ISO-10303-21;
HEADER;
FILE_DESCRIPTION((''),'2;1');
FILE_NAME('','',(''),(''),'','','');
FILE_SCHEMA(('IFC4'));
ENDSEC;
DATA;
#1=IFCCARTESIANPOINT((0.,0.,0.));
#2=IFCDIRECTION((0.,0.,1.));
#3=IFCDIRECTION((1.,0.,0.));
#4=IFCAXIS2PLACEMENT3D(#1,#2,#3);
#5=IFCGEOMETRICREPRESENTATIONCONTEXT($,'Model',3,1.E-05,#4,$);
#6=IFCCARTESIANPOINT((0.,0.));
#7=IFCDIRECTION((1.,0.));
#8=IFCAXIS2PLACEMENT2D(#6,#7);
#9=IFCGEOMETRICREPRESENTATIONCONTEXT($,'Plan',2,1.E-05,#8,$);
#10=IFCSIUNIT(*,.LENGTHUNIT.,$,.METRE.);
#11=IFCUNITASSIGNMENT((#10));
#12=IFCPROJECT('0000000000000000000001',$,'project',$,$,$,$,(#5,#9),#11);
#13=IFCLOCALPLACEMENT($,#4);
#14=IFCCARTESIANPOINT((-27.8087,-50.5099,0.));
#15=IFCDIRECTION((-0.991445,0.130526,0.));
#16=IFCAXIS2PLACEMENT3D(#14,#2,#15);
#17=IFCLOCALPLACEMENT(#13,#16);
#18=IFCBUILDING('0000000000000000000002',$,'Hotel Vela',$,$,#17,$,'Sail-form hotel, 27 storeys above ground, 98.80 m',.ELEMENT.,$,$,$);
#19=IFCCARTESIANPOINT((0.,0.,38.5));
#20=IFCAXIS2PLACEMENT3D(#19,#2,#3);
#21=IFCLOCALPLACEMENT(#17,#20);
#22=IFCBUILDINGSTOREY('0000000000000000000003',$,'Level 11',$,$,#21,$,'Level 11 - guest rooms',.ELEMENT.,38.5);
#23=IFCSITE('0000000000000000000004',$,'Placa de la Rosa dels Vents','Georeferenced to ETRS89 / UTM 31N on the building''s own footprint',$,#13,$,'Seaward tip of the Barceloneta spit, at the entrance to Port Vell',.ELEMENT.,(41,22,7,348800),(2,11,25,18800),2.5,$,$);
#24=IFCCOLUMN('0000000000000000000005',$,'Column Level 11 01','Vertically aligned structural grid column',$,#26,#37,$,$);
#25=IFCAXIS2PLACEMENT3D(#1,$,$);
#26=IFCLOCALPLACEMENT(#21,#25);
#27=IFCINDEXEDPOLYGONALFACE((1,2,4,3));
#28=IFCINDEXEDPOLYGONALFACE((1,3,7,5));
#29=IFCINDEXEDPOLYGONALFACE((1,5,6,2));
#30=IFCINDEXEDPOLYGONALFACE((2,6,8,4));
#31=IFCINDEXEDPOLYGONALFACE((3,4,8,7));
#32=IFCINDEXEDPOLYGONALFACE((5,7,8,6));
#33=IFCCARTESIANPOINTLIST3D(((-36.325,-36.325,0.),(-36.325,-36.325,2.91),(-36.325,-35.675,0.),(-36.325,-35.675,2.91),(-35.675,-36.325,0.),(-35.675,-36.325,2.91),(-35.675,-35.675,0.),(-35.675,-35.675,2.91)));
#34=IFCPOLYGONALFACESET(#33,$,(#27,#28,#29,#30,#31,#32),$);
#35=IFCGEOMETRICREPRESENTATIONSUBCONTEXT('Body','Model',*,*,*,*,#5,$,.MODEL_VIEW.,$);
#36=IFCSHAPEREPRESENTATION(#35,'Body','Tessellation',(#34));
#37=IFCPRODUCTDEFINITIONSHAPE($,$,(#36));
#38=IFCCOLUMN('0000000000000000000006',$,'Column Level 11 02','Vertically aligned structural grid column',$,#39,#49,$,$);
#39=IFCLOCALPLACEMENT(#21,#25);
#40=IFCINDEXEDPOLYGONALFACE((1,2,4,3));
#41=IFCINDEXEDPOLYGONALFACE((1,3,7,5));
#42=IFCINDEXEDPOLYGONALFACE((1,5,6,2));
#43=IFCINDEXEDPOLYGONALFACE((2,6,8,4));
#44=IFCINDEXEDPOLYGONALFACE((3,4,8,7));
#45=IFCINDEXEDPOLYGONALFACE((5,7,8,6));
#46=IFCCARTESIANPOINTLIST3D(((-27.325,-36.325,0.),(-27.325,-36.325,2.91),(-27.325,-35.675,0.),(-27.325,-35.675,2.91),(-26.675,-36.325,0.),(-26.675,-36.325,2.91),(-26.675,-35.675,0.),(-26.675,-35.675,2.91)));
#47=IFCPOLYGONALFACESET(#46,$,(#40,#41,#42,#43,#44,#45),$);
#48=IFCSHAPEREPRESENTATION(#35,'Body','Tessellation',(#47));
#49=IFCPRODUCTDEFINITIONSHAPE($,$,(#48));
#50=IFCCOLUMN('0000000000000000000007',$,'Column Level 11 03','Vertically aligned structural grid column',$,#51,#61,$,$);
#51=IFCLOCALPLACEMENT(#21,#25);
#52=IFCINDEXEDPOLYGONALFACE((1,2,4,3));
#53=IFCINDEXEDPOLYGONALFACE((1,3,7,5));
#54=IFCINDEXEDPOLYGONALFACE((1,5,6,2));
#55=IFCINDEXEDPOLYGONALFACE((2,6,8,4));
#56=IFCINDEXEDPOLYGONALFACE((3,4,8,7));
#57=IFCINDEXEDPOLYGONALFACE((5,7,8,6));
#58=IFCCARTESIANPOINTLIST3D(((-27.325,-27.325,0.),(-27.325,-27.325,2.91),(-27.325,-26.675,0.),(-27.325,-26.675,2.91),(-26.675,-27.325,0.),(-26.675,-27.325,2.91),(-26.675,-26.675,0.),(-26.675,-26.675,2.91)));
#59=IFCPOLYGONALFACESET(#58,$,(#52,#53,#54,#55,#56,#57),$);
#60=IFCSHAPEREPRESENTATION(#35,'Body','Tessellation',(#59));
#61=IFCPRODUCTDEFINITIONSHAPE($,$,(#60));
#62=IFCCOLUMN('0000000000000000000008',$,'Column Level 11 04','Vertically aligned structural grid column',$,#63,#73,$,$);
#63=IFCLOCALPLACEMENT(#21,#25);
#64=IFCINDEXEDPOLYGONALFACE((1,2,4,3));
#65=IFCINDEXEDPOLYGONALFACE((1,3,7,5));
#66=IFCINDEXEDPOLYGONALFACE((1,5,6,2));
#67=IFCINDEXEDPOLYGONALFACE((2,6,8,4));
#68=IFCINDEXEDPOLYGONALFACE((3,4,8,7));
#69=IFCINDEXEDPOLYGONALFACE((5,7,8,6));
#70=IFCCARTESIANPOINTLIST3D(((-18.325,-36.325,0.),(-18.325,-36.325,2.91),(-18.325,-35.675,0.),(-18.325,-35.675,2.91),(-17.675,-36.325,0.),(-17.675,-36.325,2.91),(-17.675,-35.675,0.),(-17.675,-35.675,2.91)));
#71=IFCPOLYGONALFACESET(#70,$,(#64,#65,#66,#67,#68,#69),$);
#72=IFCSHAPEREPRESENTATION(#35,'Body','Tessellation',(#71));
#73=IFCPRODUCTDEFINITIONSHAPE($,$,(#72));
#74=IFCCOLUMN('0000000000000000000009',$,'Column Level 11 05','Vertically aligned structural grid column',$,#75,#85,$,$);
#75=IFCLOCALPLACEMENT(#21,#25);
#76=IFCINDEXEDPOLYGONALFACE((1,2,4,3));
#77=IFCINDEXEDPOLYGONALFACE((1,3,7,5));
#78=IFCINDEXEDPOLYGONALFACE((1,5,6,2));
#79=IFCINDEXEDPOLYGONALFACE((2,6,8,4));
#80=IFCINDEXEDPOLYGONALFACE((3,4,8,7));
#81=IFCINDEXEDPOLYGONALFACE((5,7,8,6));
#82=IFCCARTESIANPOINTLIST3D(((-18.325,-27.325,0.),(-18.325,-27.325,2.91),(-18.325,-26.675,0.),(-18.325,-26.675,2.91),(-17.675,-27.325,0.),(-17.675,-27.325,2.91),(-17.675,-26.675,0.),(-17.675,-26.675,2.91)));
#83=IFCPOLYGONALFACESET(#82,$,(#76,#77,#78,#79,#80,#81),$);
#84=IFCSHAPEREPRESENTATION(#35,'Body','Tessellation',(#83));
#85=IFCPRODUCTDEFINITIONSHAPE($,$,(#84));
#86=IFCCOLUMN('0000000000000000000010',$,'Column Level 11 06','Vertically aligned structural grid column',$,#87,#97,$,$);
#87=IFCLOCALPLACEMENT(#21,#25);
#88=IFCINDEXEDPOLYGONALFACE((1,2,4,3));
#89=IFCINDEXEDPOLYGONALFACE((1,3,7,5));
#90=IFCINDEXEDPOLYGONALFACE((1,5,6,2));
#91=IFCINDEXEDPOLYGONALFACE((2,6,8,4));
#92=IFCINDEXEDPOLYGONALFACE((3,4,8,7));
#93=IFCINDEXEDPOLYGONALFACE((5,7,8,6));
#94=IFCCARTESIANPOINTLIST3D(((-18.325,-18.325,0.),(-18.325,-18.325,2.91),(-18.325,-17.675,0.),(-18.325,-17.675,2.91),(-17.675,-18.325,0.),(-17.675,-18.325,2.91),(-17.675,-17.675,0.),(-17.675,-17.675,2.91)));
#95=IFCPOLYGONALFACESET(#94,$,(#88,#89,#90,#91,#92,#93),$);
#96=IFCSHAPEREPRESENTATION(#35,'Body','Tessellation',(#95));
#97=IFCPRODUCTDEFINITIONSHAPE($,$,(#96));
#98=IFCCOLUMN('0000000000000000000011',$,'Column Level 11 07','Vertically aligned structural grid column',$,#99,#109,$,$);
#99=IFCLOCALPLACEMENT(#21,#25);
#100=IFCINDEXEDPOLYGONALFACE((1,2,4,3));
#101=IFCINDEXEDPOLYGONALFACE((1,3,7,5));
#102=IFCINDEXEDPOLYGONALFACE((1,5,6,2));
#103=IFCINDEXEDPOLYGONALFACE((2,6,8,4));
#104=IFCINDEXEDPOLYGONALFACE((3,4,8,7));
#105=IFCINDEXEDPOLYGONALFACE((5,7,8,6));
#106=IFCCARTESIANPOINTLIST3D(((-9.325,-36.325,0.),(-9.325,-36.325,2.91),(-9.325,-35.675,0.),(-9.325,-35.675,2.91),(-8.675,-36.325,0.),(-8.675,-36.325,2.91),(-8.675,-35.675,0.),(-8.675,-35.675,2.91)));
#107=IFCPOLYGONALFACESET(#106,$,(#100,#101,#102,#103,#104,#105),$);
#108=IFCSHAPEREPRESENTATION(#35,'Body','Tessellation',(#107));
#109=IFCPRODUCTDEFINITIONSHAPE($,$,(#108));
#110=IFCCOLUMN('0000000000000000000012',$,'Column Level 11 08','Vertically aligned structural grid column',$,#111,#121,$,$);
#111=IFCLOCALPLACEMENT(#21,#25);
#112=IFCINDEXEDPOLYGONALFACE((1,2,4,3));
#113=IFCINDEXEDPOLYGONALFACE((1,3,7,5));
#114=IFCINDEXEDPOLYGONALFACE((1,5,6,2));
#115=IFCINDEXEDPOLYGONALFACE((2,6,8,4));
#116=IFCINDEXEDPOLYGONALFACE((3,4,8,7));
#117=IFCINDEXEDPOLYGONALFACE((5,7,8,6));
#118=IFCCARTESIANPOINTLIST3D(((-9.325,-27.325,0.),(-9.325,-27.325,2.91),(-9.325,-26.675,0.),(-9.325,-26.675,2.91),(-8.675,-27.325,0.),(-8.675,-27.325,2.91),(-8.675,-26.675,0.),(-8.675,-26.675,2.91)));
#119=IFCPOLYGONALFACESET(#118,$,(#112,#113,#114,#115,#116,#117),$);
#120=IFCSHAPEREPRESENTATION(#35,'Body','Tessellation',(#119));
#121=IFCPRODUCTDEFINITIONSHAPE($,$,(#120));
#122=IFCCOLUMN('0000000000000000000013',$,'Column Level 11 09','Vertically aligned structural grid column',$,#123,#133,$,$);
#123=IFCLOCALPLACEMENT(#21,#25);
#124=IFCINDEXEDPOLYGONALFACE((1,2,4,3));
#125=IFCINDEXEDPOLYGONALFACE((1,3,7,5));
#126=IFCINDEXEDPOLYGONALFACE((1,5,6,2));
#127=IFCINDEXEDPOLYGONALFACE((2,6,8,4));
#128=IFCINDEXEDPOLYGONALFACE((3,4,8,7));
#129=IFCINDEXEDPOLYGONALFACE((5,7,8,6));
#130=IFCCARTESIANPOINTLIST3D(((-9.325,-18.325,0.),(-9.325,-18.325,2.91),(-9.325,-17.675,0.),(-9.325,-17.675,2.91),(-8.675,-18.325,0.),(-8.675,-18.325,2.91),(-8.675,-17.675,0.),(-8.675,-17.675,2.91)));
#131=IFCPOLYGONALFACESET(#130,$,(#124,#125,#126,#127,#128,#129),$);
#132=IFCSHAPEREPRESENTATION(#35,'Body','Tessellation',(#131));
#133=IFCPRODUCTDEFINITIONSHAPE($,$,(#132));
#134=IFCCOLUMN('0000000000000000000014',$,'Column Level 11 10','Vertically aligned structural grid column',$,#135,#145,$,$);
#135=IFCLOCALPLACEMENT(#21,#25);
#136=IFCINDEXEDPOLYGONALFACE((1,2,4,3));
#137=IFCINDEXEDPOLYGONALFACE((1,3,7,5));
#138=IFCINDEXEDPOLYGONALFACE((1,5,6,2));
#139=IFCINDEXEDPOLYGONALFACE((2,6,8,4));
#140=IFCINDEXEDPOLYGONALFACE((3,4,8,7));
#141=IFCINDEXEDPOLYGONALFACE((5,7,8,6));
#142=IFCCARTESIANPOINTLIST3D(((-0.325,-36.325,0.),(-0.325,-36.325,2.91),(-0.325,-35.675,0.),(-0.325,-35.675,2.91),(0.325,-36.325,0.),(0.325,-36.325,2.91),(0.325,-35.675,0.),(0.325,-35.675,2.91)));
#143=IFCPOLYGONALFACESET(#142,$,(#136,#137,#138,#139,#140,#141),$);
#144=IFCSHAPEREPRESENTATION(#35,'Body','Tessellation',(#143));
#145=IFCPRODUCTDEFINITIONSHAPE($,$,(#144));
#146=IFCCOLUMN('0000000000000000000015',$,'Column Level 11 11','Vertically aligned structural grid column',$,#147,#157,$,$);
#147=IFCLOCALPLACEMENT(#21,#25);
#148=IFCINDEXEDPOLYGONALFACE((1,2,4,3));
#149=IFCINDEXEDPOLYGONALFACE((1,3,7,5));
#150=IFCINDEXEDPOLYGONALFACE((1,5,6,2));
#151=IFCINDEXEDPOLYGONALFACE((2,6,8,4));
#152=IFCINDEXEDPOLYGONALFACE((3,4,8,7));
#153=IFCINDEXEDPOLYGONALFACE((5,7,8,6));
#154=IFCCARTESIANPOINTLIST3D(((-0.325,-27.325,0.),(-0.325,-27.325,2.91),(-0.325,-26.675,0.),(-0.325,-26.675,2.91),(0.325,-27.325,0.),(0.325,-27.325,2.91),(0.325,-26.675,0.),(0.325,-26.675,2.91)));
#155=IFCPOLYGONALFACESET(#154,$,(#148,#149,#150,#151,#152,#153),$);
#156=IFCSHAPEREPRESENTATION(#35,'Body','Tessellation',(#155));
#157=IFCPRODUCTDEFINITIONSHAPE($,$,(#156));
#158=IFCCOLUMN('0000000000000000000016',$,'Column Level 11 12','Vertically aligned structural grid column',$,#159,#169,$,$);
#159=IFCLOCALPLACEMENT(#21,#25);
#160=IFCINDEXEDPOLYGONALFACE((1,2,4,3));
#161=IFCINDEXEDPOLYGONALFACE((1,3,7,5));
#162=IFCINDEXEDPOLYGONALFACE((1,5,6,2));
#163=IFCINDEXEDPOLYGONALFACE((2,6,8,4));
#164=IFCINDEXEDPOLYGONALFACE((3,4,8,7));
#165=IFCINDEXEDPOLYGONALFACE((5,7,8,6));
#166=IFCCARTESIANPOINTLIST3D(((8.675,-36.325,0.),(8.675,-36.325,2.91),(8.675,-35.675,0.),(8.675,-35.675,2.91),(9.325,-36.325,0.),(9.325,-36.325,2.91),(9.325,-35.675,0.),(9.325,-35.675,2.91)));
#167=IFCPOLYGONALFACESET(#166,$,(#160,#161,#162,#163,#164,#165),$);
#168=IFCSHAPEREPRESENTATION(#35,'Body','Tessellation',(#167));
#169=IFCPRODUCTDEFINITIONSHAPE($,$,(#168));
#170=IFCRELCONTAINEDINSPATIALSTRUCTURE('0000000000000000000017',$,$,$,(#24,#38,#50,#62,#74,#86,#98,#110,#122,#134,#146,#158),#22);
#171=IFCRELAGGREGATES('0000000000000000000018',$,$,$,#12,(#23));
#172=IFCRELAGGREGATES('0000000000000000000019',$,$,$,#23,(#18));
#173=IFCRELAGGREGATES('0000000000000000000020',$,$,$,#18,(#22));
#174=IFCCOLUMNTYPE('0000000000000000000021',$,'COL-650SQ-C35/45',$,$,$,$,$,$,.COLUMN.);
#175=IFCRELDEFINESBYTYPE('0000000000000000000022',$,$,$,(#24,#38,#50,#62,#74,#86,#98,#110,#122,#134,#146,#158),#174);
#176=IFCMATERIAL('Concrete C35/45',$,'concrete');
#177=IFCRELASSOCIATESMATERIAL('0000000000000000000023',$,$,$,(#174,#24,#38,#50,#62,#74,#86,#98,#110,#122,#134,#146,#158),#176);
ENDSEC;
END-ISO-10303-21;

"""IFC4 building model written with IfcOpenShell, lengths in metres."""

from ifc_helpers import new_model, si_unit, frame, origin_with_axes, origin_2d_with_axis, place, context, subcontext, project, spatial, line, indexed_curve, rectangle, outline, extrude, material, material_profile, profile_set, profile_usage, type_object, element, save


model = new_model("IFC4")

# Units and contexts
model_context = context("Model", 3, precision=1e-05, world=origin_with_axes())
plan_context = context("Plan", 2, precision=1e-05, world=origin_2d_with_axis())
body_context = subcontext(model_context, "Body", "Model", "MODEL_VIEW")
ifc_project = project(units=[si_unit("LENGTHUNIT", "METRE")], contexts=[model_context, plan_context])

# Site, building, storey
site_placement = place(None, origin_with_axes())
site = spatial("IfcSite", under=ifc_project, at=site_placement, Name="Placa de la Rosa dels Vents", Description="Georeferenced to ETRS89 / UTM 31N on the building's own footprint", LongName="Seaward tip of the Barceloneta spit, at the entrance to Port Vell", CompositionType="ELEMENT", RefLatitude=(41, 22, 7, 348800), RefLongitude=(2, 11, 25, 18800), RefElevation=2.5)
building_placement = place(site_placement, frame((-27.8087, -50.5099, 0.0), z_axis=(0.0, 0.0, 1.0), x_axis=(-0.991445, 0.130526, 0.0)))
building = spatial("IfcBuilding", under=site, at=building_placement, Name="Hotel Vela", LongName="Sail-form hotel, 27 storeys above ground, 98.80 m", CompositionType="ELEMENT")
storey_placement = place(building_placement, frame((0.0, 0.0, 38.5), z_axis=(0.0, 0.0, 1.0), x_axis=(1.0, 0.0, 0.0)))
storey = spatial("IfcBuildingStorey", under=building, at=storey_placement, Name="Level 11", LongName="Level 11 - guest rooms", CompositionType="ELEMENT", Elevation=38.5)

# Columns
ifc_material = material(Name="Concrete C35/45", Category="concrete")
ifc_material_profile = material_profile(ifc_material, rectangle(XDim=0.65, YDim=0.65))
ifc_profile_set = profile_set([ifc_material_profile], Name="COL-650SQ-C35/45")
ifc_profile_usage_1 = profile_usage(ifc_profile_set)
column_type = type_object("IfcColumnType", Name="COL-650SQ-C35/45", PredefinedType="COLUMN", material=ifc_profile_set)
column_1_placement = place(storey_placement, frame((-36.325, -36.325, 0.0), z_axis=(0.0, 0.0, 1.0), x_axis=(1.0, 0.0, 0.0)))
element("IfcColumn", 1, at=column_1_placement, inside=storey, type_object=column_type, material=ifc_profile_usage_1, Name="Column Level 11 01", Description="Vertically aligned structural grid column", context=body_context, shape_type="SweptSolid", body=[
    extrude(outline(indexed_curve([(0.0, 0.0), (0.65, 0.0), (0.65, 0.65), (0.0, 0.65)], segments=[line(1, 2, 3, 4, 1)])), origin_with_axes(), (0.0, 0.0, 1.0), 2.91),
])
ifc_profile_usage_2 = profile_usage(ifc_profile_set)
column_2_placement = place(storey_placement, frame((-27.325, -36.325, 0.0), z_axis=(0.0, 0.0, 1.0), x_axis=(1.0, 0.0, 0.0)))
element("IfcColumn", 2, at=column_2_placement, inside=storey, type_object=column_type, material=ifc_profile_usage_2, Name="Column Level 11 02", Description="Vertically aligned structural grid column", context=body_context, shape_type="SweptSolid", body=[
    extrude(outline(indexed_curve([(0.0, 0.0), (0.65, 0.0), (0.65, 0.65), (0.0, 0.65)], segments=[line(1, 2, 3, 4, 1)])), origin_with_axes(), (0.0, 0.0, 1.0), 2.91),
])
ifc_profile_usage_3 = profile_usage(ifc_profile_set)
column_3_placement = place(storey_placement, frame((-27.325, -27.325, 0.0), z_axis=(0.0, 0.0, 1.0), x_axis=(1.0, 0.0, 0.0)))
element("IfcColumn", 3, at=column_3_placement, inside=storey, type_object=column_type, material=ifc_profile_usage_3, Name="Column Level 11 03", Description="Vertically aligned structural grid column", context=body_context, shape_type="SweptSolid", body=[
    extrude(outline(indexed_curve([(0.0, 0.0), (0.65, 0.0), (0.65, 0.65), (0.0, 0.65)], segments=[line(1, 2, 3, 4, 1)])), origin_with_axes(), (0.0, 0.0, 1.0), 2.91),
])
ifc_profile_usage_4 = profile_usage(ifc_profile_set)
column_4_placement = place(storey_placement, frame((-18.325, -36.325, 0.0), z_axis=(0.0, 0.0, 1.0), x_axis=(1.0, 0.0, 0.0)))
element("IfcColumn", 4, at=column_4_placement, inside=storey, type_object=column_type, material=ifc_profile_usage_4, Name="Column Level 11 04", Description="Vertically aligned structural grid column", context=body_context, shape_type="SweptSolid", body=[
    extrude(outline(indexed_curve([(0.0, 0.0), (0.65, 0.0), (0.65, 0.65), (0.0, 0.65)], segments=[line(1, 2, 3, 4, 1)])), origin_with_axes(), (0.0, 0.0, 1.0), 2.91),
])
ifc_profile_usage_5 = profile_usage(ifc_profile_set)
column_5_placement = place(storey_placement, frame((-18.325, -27.325, 0.0), z_axis=(0.0, 0.0, 1.0), x_axis=(1.0, 0.0, 0.0)))
element("IfcColumn", 5, at=column_5_placement, inside=storey, type_object=column_type, material=ifc_profile_usage_5, Name="Column Level 11 05", Description="Vertically aligned structural grid column", context=body_context, shape_type="SweptSolid", body=[
    extrude(outline(indexed_curve([(0.0, 0.0), (0.65, 0.0), (0.65, 0.65), (0.0, 0.65)], segments=[line(1, 2, 3, 4, 1)])), origin_with_axes(), (0.0, 0.0, 1.0), 2.91),
])
ifc_profile_usage_6 = profile_usage(ifc_profile_set)
column_6_placement = place(storey_placement, frame((-18.325, -18.325, 0.0), z_axis=(0.0, 0.0, 1.0), x_axis=(1.0, 0.0, 0.0)))
element("IfcColumn", 6, at=column_6_placement, inside=storey, type_object=column_type, material=ifc_profile_usage_6, Name="Column Level 11 06", Description="Vertically aligned structural grid column", context=body_context, shape_type="SweptSolid", body=[
    extrude(outline(indexed_curve([(0.0, 0.0), (0.65, 0.0), (0.65, 0.65), (0.0, 0.65)], segments=[line(1, 2, 3, 4, 1)])), origin_with_axes(), (0.0, 0.0, 1.0), 2.91),
])
ifc_profile_usage_7 = profile_usage(ifc_profile_set)
column_7_placement = place(storey_placement, frame((-9.325, -36.325, 0.0), z_axis=(0.0, 0.0, 1.0), x_axis=(1.0, 0.0, 0.0)))
element("IfcColumn", 7, at=column_7_placement, inside=storey, type_object=column_type, material=ifc_profile_usage_7, Name="Column Level 11 07", Description="Vertically aligned structural grid column", context=body_context, shape_type="SweptSolid", body=[
    extrude(outline(indexed_curve([(0.0, 0.0), (0.65, 0.0), (0.65, 0.65), (0.0, 0.65)], segments=[line(1, 2, 3, 4, 1)])), origin_with_axes(), (0.0, 0.0, 1.0), 2.91),
])
ifc_profile_usage_8 = profile_usage(ifc_profile_set)
column_8_placement = place(storey_placement, frame((-9.325, -27.325, 0.0), z_axis=(0.0, 0.0, 1.0), x_axis=(1.0, 0.0, 0.0)))
element("IfcColumn", 8, at=column_8_placement, inside=storey, type_object=column_type, material=ifc_profile_usage_8, Name="Column Level 11 08", Description="Vertically aligned structural grid column", context=body_context, shape_type="SweptSolid", body=[
    extrude(outline(indexed_curve([(0.0, 0.0), (0.65, 0.0), (0.65, 0.65), (0.0, 0.65)], segments=[line(1, 2, 3, 4, 1)])), origin_with_axes(), (0.0, 0.0, 1.0), 2.91),
])
ifc_profile_usage_9 = profile_usage(ifc_profile_set)
column_9_placement = place(storey_placement, frame((-9.325, -18.325, 0.0), z_axis=(0.0, 0.0, 1.0), x_axis=(1.0, 0.0, 0.0)))
element("IfcColumn", 9, at=column_9_placement, inside=storey, type_object=column_type, material=ifc_profile_usage_9, Name="Column Level 11 09", Description="Vertically aligned structural grid column", context=body_context, shape_type="SweptSolid", body=[
    extrude(outline(indexed_curve([(0.0, 0.0), (0.65, 0.0), (0.65, 0.65), (0.0, 0.65)], segments=[line(1, 2, 3, 4, 1)])), origin_with_axes(), (0.0, 0.0, 1.0), 2.91),
])
ifc_profile_usage_10 = profile_usage(ifc_profile_set)
column_10_placement = place(storey_placement, frame((-0.325, -36.325, 0.0), z_axis=(0.0, 0.0, 1.0), x_axis=(1.0, 0.0, 0.0)))
element("IfcColumn", 10, at=column_10_placement, inside=storey, type_object=column_type, material=ifc_profile_usage_10, Name="Column Level 11 10", Description="Vertically aligned structural grid column", context=body_context, shape_type="SweptSolid", body=[
    extrude(outline(indexed_curve([(0.0, 0.0), (0.65, 0.0), (0.65, 0.65), (0.0, 0.65)], segments=[line(1, 2, 3, 4, 1)])), origin_with_axes(), (0.0, 0.0, 1.0), 2.91),
])
ifc_profile_usage_11 = profile_usage(ifc_profile_set)
column_11_placement = place(storey_placement, frame((-0.325, -27.325, 0.0), z_axis=(0.0, 0.0, 1.0), x_axis=(1.0, 0.0, 0.0)))
element("IfcColumn", 11, at=column_11_placement, inside=storey, type_object=column_type, material=ifc_profile_usage_11, Name="Column Level 11 11", Description="Vertically aligned structural grid column", context=body_context, shape_type="SweptSolid", body=[
    extrude(outline(indexed_curve([(0.0, 0.0), (0.65, 0.0), (0.65, 0.65), (0.0, 0.65)], segments=[line(1, 2, 3, 4, 1)])), origin_with_axes(), (0.0, 0.0, 1.0), 2.91),
])
ifc_profile_usage_12 = profile_usage(ifc_profile_set)
column_12_placement = place(storey_placement, frame((8.675, -36.325, 0.0), z_axis=(0.0, 0.0, 1.0), x_axis=(1.0, 0.0, 0.0)))
element("IfcColumn", 12, at=column_12_placement, inside=storey, type_object=column_type, material=ifc_profile_usage_12, Name="Column Level 11 12", Description="Vertically aligned structural grid column", context=body_context, shape_type="SweptSolid", body=[
    extrude(outline(indexed_curve([(0.0, 0.0), (0.65, 0.0), (0.65, 0.65), (0.0, 0.65)], segments=[line(1, 2, 3, 4, 1)])), origin_with_axes(), (0.0, 0.0, 1.0), 2.91),
])

save(model, "model.ifc")
